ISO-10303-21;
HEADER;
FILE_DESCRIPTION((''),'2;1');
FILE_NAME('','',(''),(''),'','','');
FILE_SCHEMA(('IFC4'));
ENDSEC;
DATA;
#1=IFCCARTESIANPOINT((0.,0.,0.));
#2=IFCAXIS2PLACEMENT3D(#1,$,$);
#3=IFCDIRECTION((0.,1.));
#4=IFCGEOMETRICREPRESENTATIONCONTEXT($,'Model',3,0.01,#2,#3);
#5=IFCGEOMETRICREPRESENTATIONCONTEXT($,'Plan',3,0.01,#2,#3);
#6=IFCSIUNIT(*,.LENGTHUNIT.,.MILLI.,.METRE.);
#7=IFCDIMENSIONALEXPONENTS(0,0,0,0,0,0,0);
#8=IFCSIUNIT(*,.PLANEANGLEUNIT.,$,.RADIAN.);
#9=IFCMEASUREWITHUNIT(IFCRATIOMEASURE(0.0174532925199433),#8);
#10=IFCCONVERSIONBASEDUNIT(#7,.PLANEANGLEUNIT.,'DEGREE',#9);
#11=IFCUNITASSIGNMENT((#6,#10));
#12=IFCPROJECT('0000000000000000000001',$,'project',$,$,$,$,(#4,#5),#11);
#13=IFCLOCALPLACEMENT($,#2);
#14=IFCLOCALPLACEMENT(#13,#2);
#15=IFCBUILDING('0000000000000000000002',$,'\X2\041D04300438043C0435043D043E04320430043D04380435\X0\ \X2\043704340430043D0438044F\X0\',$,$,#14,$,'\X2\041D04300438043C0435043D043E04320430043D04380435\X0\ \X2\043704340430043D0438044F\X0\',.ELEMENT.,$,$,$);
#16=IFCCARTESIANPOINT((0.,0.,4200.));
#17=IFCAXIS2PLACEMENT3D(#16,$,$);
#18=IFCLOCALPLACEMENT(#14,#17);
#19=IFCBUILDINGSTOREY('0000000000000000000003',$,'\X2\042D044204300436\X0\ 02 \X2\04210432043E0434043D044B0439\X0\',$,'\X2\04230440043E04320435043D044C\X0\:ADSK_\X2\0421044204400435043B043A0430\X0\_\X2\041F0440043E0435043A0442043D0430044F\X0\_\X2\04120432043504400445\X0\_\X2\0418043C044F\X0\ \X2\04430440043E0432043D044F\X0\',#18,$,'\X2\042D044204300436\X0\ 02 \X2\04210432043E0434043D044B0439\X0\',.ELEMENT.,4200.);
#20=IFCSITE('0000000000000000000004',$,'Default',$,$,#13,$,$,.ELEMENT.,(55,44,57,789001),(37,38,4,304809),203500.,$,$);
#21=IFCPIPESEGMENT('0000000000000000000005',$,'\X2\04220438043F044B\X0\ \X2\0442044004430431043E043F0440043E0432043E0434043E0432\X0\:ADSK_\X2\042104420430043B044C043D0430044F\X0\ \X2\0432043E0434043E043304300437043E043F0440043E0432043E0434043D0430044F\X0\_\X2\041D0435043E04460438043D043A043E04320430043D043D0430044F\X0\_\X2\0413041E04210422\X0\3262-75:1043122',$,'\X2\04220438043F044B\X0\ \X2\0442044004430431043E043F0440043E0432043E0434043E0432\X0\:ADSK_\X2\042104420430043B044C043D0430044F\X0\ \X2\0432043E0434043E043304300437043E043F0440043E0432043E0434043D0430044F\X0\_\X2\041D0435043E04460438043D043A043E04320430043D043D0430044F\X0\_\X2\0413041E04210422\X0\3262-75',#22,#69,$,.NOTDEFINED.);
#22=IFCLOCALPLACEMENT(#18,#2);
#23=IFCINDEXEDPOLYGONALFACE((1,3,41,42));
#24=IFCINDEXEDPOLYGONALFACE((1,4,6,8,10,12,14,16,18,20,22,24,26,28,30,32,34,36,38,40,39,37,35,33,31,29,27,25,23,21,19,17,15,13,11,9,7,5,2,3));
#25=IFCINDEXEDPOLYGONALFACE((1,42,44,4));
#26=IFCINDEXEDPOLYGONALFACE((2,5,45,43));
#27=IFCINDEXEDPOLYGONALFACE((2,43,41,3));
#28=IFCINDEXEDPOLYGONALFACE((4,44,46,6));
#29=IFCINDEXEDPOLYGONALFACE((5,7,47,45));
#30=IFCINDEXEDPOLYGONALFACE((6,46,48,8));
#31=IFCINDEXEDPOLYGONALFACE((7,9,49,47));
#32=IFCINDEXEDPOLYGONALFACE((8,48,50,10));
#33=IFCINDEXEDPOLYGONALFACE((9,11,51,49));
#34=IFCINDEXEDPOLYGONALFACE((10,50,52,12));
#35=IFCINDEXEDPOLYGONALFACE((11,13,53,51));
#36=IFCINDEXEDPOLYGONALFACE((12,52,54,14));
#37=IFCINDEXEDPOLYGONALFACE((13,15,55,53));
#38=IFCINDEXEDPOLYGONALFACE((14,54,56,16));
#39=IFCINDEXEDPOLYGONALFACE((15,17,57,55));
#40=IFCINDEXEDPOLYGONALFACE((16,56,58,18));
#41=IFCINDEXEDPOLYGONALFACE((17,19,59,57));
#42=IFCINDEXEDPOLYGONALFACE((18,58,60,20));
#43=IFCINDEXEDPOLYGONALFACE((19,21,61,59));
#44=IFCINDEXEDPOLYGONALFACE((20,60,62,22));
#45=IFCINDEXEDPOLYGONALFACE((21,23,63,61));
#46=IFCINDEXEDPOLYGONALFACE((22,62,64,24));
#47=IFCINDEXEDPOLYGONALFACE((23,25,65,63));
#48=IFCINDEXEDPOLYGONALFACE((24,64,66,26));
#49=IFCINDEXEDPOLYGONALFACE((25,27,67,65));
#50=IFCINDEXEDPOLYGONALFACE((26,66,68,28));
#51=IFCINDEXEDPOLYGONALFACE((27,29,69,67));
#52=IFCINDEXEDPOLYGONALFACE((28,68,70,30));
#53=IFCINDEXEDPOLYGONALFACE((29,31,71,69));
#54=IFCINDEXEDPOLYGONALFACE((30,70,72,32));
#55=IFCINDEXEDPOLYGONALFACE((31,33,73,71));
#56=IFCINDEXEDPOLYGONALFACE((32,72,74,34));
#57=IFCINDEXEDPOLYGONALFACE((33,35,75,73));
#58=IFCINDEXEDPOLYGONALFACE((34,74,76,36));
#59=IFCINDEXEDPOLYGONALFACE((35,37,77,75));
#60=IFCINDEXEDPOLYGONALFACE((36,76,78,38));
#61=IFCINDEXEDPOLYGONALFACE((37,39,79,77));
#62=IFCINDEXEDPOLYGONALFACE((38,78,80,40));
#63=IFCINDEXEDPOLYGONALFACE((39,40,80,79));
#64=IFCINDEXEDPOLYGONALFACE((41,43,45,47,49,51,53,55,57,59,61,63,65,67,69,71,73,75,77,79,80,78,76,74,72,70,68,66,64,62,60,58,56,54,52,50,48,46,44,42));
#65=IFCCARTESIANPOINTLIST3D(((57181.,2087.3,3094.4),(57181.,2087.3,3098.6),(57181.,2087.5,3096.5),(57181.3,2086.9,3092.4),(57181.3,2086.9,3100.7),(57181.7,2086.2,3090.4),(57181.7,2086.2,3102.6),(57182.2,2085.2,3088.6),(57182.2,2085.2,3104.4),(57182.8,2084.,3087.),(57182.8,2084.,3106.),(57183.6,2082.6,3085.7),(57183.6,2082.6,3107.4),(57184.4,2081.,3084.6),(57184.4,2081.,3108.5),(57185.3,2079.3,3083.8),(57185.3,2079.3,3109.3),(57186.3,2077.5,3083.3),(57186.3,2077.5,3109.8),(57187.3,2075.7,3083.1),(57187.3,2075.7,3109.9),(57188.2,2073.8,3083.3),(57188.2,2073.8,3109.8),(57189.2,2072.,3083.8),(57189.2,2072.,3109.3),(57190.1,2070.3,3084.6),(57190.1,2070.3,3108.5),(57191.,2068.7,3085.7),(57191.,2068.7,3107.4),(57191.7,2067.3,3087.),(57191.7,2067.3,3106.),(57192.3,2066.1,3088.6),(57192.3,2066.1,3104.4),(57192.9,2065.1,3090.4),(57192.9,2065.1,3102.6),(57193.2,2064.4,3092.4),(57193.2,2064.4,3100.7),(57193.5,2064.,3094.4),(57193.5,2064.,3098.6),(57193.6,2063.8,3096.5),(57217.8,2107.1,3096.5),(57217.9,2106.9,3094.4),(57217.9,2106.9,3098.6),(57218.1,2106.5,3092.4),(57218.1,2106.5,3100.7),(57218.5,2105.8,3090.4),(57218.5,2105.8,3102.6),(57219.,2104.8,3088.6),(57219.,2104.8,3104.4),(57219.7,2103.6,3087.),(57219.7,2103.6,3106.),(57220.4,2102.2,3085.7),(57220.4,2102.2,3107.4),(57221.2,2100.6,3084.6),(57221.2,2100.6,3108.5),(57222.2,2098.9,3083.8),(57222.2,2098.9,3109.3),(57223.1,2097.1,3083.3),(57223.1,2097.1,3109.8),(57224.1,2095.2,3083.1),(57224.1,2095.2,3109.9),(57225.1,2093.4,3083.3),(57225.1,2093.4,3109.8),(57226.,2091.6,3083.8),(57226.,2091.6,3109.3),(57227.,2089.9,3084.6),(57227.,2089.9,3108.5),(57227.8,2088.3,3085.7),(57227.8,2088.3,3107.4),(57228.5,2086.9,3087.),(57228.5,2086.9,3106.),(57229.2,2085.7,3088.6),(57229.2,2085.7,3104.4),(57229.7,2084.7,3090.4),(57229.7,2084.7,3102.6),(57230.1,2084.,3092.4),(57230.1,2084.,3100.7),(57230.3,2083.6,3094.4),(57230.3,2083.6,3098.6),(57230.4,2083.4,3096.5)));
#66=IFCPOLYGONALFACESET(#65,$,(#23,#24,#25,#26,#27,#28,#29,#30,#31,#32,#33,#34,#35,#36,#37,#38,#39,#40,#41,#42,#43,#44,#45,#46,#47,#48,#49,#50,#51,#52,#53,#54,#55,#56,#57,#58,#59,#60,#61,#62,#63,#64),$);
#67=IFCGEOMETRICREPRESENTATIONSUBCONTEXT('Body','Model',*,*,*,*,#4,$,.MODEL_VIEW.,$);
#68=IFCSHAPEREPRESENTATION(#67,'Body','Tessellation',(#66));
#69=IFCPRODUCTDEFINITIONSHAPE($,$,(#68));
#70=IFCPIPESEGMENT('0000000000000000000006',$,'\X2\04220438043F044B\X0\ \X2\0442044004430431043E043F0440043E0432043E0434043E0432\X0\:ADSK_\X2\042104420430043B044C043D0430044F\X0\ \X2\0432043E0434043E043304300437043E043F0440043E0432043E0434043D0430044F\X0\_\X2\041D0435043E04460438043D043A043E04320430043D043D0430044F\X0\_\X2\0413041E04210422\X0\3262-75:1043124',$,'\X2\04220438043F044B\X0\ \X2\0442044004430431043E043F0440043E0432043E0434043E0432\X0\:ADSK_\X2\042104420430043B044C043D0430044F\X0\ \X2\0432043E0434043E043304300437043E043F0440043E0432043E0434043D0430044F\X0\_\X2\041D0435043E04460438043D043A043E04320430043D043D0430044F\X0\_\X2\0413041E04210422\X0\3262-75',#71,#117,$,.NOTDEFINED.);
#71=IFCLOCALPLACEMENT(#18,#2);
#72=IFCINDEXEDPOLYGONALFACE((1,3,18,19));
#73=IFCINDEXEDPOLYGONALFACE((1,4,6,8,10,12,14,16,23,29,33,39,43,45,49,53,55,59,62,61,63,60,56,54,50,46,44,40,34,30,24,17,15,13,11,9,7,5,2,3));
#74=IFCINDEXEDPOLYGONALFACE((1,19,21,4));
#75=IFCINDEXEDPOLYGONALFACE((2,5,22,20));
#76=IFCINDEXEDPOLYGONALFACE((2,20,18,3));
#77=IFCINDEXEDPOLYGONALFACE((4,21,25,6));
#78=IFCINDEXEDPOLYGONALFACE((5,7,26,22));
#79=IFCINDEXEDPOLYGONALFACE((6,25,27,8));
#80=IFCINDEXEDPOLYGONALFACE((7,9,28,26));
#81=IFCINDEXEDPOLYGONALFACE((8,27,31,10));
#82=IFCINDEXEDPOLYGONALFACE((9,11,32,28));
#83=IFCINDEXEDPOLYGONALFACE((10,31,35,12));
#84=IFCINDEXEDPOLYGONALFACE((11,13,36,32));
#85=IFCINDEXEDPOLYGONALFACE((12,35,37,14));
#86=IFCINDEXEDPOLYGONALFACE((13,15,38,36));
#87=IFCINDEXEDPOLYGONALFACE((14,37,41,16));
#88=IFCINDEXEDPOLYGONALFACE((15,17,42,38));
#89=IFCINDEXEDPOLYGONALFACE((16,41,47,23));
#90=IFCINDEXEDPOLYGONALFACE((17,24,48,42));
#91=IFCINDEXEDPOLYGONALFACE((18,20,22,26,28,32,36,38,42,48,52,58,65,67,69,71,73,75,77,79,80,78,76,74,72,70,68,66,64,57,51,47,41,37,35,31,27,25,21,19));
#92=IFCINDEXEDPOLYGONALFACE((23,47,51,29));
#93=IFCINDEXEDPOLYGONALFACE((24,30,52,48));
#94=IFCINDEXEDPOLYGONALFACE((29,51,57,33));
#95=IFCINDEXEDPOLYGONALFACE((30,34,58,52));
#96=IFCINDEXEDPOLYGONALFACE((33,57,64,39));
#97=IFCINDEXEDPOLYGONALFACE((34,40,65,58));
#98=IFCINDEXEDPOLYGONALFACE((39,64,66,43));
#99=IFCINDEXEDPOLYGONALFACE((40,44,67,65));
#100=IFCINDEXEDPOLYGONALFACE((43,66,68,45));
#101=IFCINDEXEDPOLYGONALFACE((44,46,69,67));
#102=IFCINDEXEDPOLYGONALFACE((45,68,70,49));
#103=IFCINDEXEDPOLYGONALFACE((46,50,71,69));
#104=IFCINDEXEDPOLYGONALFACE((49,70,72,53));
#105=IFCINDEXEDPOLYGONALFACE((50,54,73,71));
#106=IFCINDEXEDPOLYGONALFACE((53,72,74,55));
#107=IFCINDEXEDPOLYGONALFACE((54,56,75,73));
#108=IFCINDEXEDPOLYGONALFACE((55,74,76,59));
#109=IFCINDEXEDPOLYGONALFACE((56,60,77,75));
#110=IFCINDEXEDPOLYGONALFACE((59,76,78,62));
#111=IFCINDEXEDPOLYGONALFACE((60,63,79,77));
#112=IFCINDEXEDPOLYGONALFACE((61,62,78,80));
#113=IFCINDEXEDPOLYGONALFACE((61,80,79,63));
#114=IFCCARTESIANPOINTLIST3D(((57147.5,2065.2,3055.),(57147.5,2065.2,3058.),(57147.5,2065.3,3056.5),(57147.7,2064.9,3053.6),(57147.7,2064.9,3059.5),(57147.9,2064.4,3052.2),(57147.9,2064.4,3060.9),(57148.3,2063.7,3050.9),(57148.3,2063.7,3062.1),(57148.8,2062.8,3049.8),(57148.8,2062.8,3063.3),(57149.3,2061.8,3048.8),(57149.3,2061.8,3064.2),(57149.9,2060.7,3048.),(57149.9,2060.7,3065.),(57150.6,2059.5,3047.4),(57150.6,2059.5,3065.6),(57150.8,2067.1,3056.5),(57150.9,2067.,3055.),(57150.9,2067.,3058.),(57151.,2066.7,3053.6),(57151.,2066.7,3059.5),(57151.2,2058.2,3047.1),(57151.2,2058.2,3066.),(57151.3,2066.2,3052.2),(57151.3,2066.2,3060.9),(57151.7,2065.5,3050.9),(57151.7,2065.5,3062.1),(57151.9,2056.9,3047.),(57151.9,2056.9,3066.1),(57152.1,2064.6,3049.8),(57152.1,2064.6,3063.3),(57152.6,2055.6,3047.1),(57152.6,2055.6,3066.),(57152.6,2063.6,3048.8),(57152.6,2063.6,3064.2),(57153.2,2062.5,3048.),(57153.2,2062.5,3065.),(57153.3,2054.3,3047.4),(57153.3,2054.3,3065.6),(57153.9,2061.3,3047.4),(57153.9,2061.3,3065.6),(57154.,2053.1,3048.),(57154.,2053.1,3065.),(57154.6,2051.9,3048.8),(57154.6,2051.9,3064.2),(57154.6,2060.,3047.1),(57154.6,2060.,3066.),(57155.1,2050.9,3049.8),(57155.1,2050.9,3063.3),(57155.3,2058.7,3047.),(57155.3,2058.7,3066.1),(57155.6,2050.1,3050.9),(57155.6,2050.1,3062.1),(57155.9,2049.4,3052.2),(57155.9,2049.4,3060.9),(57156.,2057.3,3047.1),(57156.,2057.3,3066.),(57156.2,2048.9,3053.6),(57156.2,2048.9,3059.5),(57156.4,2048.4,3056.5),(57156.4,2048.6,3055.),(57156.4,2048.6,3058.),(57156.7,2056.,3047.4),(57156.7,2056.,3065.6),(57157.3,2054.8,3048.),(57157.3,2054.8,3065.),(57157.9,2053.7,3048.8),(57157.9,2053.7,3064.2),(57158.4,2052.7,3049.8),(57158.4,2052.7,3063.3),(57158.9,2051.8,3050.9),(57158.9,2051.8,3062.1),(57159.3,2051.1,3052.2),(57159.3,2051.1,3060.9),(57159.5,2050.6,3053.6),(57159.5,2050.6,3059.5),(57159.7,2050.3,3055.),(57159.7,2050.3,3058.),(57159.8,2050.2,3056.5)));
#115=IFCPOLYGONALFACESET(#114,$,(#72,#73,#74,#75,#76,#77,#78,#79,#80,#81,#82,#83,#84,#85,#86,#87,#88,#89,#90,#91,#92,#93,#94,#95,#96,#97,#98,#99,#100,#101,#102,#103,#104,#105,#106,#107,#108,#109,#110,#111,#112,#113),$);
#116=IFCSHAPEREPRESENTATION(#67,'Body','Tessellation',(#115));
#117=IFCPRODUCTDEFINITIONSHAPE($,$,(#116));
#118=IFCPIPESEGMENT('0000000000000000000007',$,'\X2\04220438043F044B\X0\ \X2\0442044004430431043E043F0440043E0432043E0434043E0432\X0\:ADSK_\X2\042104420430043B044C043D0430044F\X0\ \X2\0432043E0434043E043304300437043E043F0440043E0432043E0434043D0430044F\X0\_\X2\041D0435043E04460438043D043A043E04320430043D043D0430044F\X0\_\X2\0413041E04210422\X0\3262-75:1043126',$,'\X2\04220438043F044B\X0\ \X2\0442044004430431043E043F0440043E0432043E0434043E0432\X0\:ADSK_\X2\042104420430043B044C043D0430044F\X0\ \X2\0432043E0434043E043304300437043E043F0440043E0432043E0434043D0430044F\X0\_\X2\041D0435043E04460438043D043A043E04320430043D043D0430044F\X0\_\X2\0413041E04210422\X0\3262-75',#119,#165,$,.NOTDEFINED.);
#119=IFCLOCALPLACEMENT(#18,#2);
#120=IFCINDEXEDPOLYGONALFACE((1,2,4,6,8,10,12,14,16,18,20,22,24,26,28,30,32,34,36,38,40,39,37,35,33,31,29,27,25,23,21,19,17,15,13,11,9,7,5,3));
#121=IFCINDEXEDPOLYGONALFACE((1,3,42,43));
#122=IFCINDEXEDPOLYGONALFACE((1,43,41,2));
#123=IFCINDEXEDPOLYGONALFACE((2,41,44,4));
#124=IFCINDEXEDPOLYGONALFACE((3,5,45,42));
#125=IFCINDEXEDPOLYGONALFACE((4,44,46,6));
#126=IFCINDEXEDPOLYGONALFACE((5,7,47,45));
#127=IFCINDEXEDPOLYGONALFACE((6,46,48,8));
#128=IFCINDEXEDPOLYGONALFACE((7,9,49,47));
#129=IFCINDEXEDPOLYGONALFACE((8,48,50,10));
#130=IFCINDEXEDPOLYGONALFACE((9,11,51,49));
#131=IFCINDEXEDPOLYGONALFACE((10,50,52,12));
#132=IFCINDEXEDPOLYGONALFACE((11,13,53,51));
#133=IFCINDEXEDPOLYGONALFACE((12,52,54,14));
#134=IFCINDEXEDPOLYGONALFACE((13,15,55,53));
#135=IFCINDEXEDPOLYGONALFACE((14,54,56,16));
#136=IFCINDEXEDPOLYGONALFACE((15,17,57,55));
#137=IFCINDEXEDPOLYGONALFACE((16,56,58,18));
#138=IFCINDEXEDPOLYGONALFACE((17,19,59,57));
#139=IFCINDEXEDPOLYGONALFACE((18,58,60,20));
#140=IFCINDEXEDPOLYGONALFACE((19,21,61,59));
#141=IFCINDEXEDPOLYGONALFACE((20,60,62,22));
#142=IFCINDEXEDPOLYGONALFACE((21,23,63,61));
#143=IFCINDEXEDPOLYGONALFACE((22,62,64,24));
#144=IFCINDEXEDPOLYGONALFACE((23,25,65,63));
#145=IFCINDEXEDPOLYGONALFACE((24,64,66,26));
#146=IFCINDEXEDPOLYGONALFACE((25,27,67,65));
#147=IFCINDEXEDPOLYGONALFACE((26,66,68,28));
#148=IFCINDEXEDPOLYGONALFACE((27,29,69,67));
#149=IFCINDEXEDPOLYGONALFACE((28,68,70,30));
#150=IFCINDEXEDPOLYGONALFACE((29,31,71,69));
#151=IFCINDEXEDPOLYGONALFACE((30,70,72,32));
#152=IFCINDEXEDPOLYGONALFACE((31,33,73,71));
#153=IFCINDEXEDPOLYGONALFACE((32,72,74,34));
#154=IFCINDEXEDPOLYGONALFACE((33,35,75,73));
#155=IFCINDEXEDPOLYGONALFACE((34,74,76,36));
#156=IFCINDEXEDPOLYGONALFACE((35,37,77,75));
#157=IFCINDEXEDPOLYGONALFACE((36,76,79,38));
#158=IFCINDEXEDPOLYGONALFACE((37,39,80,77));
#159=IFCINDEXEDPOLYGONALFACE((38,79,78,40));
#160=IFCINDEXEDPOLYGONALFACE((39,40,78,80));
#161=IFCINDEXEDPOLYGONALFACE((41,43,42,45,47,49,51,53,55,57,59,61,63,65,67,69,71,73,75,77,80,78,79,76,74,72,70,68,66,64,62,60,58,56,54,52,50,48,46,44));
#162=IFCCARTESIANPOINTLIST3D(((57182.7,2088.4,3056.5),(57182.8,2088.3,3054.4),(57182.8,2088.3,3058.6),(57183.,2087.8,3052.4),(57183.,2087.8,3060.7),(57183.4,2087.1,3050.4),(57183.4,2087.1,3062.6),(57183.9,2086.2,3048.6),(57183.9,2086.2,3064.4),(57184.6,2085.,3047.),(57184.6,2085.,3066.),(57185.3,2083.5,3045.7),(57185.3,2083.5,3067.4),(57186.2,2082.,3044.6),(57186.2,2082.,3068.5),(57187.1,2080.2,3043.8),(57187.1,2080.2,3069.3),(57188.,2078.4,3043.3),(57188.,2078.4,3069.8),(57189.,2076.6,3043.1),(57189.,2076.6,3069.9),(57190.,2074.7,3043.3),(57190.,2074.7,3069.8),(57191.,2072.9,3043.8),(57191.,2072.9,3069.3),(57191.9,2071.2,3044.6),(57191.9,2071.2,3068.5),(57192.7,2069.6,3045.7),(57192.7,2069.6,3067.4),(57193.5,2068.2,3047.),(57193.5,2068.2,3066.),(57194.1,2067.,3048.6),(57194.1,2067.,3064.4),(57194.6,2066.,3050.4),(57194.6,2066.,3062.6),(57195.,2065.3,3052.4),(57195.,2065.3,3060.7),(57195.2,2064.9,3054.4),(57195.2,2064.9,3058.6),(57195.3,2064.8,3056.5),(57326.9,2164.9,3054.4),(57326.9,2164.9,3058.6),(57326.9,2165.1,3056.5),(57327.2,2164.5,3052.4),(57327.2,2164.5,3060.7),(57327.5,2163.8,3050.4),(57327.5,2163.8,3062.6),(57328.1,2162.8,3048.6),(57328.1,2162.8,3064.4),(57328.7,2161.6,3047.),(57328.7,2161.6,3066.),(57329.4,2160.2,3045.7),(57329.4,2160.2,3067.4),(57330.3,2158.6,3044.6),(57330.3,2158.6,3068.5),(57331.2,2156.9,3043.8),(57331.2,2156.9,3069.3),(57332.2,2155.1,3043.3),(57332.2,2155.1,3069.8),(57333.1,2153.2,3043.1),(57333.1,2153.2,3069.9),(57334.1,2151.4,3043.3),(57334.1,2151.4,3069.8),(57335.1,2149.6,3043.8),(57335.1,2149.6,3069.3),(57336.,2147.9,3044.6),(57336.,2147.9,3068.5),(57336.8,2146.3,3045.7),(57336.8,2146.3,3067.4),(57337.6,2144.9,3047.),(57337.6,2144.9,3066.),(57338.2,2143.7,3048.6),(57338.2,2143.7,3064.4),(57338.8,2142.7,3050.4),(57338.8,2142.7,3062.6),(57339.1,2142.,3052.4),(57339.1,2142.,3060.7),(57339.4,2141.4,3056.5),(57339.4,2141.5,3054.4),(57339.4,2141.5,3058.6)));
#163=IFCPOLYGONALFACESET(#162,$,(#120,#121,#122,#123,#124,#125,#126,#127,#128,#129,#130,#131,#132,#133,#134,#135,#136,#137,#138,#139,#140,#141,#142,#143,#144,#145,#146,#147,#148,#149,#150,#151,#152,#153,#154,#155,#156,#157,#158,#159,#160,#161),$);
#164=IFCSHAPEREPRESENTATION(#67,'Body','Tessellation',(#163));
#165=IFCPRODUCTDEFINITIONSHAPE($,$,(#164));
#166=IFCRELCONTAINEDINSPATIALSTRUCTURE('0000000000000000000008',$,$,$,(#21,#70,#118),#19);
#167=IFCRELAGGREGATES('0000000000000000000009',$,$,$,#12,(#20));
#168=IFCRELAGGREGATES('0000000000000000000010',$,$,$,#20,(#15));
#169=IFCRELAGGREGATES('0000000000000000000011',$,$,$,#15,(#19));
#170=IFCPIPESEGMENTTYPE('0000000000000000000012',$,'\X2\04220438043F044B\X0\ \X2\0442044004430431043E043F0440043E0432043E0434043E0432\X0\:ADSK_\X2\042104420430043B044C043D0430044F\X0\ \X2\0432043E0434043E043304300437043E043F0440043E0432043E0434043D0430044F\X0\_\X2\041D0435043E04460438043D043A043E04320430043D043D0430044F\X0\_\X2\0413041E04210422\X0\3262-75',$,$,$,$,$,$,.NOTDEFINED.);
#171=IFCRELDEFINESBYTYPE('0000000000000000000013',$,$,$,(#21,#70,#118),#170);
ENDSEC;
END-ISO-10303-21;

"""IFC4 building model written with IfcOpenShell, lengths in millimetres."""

from ifc_helpers import new_model, entity, si_unit, converted_unit, direction, frame, origin, place, context, subcontext, project, spatial, indexed_curve, outline, extrude, type_object, element, save


model = new_model("IFC4")

# Units and contexts
model_context = context("Model", 3, precision=0.01, world=origin(), true_north=direction((0.0, 1.0)))
plan_context = context("Plan", 3, precision=0.01, world=origin(), true_north=direction((0.0, 1.0)))
body_context = subcontext(model_context, "Body", "Model", "MODEL_VIEW")
ifc_project = project(units=[si_unit("LENGTHUNIT", "METRE", prefix="MILLI"), converted_unit("PLANEANGLEUNIT", "DEGREE", entity("IfcRatioMeasure", 0.0174532925199433), si_unit("PLANEANGLEUNIT", "RADIAN"), dimensions=[0, 0, 0, 0, 0, 0, 0])], contexts=[model_context, plan_context])

# Site, building, storey
site_placement = place(None, origin())
site = spatial("IfcSite", under=ifc_project, at=site_placement, Name="Default", CompositionType="ELEMENT", RefLatitude=(55, 44, 57, 789001), RefLongitude=(37, 38, 4, 304809), RefElevation=203500.0)
building_placement = place(site_placement, origin())
building = spatial("IfcBuilding", under=site, at=building_placement, Name="Наименование здания", LongName="Наименование здания", CompositionType="ELEMENT")
storey_placement = place(building_placement, frame((0.0, 0.0, 4200.0)))
storey = spatial("IfcBuildingStorey", under=building, at=storey_placement, Name="Этаж 02 Сводный", ObjectType="Уровень:ADSK_Стрелка_Проектная_Вверх_Имя уровня", LongName="Этаж 02 Сводный", CompositionType="ELEMENT", Elevation=4200.0)

# Pipe segments
pipe_segment_type = type_object("IfcPipeSegmentType", Name="Типы трубопроводов:ADSK_Стальная водогазопроводная_Неоцинкованная_ГОСТ3262-75", PredefinedType="NOTDEFINED")
placement = place(storey_placement, origin())
element("IfcPipeSegment", 1, at=placement, inside=storey, type_object=pipe_segment_type, Name="Типы трубопроводов:ADSK_Стальная водогазопроводная_Неоцинкованная_ГОСТ3262-75:1043122", ObjectType="Типы трубопроводов:ADSK_Стальная водогазопроводная_Неоцинкованная_ГОСТ3262-75", PredefinedType="NOTDEFINED", context=body_context, shape_type="SweptSolid", body=[
    extrude(outline(indexed_curve([(13.4, 0.0), (13.2, 2.1), (12.7, 4.1), (11.9, 6.1), (10.8, 7.9), (9.5, 9.5), (7.9, 10.8), (6.1, 11.9), (4.1, 12.7), (2.1, 13.2), (0.0, 13.4), (-2.1, 13.2), (-4.1, 12.7), (-6.1, 11.9), (-7.9, 10.8), (-9.5, 9.5), (-10.8, 7.9), (-11.9, 6.1), (-12.7, 4.1), (-13.2, 2.1), (-13.4, 0.0), (-13.2, -2.1), (-12.7, -4.1), (-11.9, -6.1), (-10.8, -7.9), (-9.5, -9.5), (-7.9, -10.8), (-6.1, -11.9), (-4.1, -12.7), (-2.1, -13.2), (0.0, -13.4), (2.1, -13.2), (4.1, -12.7), (6.1, -11.9), (7.9, -10.8), (9.5, -9.5), (10.8, -7.9), (11.9, -6.1), (12.7, -4.1), (13.2, -2.1), (13.4, 0.0)], self_intersect=False)), frame((57187.3, 2075.7, 3096.5), z_axis=(0.882948, 0.469472, 0.0), x_axis=(0.469472, -0.882948, 0.0)), (0.0, 0.0, 1.0), 41.7),
])
element("IfcPipeSegment", 2, at=placement, inside=storey, type_object=pipe_segment_type, Name="Типы трубопроводов:ADSK_Стальная водогазопроводная_Неоцинкованная_ГОСТ3262-75:1043124", ObjectType="Типы трубопроводов:ADSK_Стальная водогазопроводная_Неоцинкованная_ГОСТ3262-75", PredefinedType="NOTDEFINED", context=body_context, shape_type="SweptSolid", body=[
    extrude(outline(indexed_curve([(9.6, 0.0), (9.4, 1.5), (9.1, 3.0), (8.5, 4.3), (7.7, 5.6), (6.8, 6.8), (5.6, 7.7), (4.3, 8.5), (3.0, 9.1), (1.5, 9.4), (0.0, 9.6), (-1.5, 9.4), (-3.0, 9.1), (-4.3, 8.5), (-5.6, 7.7), (-6.8, 6.8), (-7.7, 5.6), (-8.5, 4.3), (-9.1, 3.0), (-9.4, 1.5), (-9.6, 0.0), (-9.4, -1.5), (-9.1, -3.0), (-8.5, -4.3), (-7.7, -5.6), (-6.8, -6.8), (-5.6, -7.7), (-4.3, -8.5), (-3.0, -9.1), (-1.5, -9.4), (0.0, -9.6), (1.5, -9.4), (3.0, -9.1), (4.3, -8.5), (5.6, -7.7), (6.8, -6.8), (7.7, -5.6), (8.5, -4.3), (9.1, -3.0), (9.4, -1.5), (9.6, 0.0)], self_intersect=False)), frame((57151.9, 2056.9, 3056.5), z_axis=(0.882948, 0.469472, 0.0), x_axis=(0.469472, -0.882948, 0.0)), (0.0, 0.0, 1.0), 3.8),
])
element("IfcPipeSegment", 3, at=placement, inside=storey, type_object=pipe_segment_type, Name="Типы трубопроводов:ADSK_Стальная водогазопроводная_Неоцинкованная_ГОСТ3262-75:1043126", ObjectType="Типы трубопроводов:ADSK_Стальная водогазопроводная_Неоцинкованная_ГОСТ3262-75", PredefinedType="NOTDEFINED", context=body_context, shape_type="SweptSolid", body=[
    extrude(outline(indexed_curve([(13.4, 0.0), (13.2, 2.1), (12.7, 4.1), (11.9, 6.1), (10.8, 7.9), (9.5, 9.5), (7.9, 10.8), (6.1, 11.9), (4.1, 12.7), (2.1, 13.2), (0.0, 13.4), (-2.1, 13.2), (-4.1, 12.7), (-6.1, 11.9), (-7.9, 10.8), (-9.5, 9.5), (-10.8, 7.9), (-11.9, 6.1), (-12.7, 4.1), (-13.2, 2.1), (-13.4, 0.0), (-13.2, -2.1), (-12.7, -4.1), (-11.9, -6.1), (-10.8, -7.9), (-9.5, -9.5), (-7.9, -10.8), (-6.1, -11.9), (-4.1, -12.7), (-2.1, -13.2), (0.0, -13.4), (2.1, -13.2), (4.1, -12.7), (6.1, -11.9), (7.9, -10.8), (9.5, -9.5), (10.8, -7.9), (11.9, -6.1), (12.7, -4.1), (13.2, -2.1), (13.4, 0.0)], self_intersect=False)), frame((57189.0, 2076.6, 3056.5), z_axis=(0.882948, 0.469472, 0.0), x_axis=(-0.469472, 0.882948, 0.0)), (0.0, 0.0, 1.0), 163.2),
])

save(model, "model.ifc")
